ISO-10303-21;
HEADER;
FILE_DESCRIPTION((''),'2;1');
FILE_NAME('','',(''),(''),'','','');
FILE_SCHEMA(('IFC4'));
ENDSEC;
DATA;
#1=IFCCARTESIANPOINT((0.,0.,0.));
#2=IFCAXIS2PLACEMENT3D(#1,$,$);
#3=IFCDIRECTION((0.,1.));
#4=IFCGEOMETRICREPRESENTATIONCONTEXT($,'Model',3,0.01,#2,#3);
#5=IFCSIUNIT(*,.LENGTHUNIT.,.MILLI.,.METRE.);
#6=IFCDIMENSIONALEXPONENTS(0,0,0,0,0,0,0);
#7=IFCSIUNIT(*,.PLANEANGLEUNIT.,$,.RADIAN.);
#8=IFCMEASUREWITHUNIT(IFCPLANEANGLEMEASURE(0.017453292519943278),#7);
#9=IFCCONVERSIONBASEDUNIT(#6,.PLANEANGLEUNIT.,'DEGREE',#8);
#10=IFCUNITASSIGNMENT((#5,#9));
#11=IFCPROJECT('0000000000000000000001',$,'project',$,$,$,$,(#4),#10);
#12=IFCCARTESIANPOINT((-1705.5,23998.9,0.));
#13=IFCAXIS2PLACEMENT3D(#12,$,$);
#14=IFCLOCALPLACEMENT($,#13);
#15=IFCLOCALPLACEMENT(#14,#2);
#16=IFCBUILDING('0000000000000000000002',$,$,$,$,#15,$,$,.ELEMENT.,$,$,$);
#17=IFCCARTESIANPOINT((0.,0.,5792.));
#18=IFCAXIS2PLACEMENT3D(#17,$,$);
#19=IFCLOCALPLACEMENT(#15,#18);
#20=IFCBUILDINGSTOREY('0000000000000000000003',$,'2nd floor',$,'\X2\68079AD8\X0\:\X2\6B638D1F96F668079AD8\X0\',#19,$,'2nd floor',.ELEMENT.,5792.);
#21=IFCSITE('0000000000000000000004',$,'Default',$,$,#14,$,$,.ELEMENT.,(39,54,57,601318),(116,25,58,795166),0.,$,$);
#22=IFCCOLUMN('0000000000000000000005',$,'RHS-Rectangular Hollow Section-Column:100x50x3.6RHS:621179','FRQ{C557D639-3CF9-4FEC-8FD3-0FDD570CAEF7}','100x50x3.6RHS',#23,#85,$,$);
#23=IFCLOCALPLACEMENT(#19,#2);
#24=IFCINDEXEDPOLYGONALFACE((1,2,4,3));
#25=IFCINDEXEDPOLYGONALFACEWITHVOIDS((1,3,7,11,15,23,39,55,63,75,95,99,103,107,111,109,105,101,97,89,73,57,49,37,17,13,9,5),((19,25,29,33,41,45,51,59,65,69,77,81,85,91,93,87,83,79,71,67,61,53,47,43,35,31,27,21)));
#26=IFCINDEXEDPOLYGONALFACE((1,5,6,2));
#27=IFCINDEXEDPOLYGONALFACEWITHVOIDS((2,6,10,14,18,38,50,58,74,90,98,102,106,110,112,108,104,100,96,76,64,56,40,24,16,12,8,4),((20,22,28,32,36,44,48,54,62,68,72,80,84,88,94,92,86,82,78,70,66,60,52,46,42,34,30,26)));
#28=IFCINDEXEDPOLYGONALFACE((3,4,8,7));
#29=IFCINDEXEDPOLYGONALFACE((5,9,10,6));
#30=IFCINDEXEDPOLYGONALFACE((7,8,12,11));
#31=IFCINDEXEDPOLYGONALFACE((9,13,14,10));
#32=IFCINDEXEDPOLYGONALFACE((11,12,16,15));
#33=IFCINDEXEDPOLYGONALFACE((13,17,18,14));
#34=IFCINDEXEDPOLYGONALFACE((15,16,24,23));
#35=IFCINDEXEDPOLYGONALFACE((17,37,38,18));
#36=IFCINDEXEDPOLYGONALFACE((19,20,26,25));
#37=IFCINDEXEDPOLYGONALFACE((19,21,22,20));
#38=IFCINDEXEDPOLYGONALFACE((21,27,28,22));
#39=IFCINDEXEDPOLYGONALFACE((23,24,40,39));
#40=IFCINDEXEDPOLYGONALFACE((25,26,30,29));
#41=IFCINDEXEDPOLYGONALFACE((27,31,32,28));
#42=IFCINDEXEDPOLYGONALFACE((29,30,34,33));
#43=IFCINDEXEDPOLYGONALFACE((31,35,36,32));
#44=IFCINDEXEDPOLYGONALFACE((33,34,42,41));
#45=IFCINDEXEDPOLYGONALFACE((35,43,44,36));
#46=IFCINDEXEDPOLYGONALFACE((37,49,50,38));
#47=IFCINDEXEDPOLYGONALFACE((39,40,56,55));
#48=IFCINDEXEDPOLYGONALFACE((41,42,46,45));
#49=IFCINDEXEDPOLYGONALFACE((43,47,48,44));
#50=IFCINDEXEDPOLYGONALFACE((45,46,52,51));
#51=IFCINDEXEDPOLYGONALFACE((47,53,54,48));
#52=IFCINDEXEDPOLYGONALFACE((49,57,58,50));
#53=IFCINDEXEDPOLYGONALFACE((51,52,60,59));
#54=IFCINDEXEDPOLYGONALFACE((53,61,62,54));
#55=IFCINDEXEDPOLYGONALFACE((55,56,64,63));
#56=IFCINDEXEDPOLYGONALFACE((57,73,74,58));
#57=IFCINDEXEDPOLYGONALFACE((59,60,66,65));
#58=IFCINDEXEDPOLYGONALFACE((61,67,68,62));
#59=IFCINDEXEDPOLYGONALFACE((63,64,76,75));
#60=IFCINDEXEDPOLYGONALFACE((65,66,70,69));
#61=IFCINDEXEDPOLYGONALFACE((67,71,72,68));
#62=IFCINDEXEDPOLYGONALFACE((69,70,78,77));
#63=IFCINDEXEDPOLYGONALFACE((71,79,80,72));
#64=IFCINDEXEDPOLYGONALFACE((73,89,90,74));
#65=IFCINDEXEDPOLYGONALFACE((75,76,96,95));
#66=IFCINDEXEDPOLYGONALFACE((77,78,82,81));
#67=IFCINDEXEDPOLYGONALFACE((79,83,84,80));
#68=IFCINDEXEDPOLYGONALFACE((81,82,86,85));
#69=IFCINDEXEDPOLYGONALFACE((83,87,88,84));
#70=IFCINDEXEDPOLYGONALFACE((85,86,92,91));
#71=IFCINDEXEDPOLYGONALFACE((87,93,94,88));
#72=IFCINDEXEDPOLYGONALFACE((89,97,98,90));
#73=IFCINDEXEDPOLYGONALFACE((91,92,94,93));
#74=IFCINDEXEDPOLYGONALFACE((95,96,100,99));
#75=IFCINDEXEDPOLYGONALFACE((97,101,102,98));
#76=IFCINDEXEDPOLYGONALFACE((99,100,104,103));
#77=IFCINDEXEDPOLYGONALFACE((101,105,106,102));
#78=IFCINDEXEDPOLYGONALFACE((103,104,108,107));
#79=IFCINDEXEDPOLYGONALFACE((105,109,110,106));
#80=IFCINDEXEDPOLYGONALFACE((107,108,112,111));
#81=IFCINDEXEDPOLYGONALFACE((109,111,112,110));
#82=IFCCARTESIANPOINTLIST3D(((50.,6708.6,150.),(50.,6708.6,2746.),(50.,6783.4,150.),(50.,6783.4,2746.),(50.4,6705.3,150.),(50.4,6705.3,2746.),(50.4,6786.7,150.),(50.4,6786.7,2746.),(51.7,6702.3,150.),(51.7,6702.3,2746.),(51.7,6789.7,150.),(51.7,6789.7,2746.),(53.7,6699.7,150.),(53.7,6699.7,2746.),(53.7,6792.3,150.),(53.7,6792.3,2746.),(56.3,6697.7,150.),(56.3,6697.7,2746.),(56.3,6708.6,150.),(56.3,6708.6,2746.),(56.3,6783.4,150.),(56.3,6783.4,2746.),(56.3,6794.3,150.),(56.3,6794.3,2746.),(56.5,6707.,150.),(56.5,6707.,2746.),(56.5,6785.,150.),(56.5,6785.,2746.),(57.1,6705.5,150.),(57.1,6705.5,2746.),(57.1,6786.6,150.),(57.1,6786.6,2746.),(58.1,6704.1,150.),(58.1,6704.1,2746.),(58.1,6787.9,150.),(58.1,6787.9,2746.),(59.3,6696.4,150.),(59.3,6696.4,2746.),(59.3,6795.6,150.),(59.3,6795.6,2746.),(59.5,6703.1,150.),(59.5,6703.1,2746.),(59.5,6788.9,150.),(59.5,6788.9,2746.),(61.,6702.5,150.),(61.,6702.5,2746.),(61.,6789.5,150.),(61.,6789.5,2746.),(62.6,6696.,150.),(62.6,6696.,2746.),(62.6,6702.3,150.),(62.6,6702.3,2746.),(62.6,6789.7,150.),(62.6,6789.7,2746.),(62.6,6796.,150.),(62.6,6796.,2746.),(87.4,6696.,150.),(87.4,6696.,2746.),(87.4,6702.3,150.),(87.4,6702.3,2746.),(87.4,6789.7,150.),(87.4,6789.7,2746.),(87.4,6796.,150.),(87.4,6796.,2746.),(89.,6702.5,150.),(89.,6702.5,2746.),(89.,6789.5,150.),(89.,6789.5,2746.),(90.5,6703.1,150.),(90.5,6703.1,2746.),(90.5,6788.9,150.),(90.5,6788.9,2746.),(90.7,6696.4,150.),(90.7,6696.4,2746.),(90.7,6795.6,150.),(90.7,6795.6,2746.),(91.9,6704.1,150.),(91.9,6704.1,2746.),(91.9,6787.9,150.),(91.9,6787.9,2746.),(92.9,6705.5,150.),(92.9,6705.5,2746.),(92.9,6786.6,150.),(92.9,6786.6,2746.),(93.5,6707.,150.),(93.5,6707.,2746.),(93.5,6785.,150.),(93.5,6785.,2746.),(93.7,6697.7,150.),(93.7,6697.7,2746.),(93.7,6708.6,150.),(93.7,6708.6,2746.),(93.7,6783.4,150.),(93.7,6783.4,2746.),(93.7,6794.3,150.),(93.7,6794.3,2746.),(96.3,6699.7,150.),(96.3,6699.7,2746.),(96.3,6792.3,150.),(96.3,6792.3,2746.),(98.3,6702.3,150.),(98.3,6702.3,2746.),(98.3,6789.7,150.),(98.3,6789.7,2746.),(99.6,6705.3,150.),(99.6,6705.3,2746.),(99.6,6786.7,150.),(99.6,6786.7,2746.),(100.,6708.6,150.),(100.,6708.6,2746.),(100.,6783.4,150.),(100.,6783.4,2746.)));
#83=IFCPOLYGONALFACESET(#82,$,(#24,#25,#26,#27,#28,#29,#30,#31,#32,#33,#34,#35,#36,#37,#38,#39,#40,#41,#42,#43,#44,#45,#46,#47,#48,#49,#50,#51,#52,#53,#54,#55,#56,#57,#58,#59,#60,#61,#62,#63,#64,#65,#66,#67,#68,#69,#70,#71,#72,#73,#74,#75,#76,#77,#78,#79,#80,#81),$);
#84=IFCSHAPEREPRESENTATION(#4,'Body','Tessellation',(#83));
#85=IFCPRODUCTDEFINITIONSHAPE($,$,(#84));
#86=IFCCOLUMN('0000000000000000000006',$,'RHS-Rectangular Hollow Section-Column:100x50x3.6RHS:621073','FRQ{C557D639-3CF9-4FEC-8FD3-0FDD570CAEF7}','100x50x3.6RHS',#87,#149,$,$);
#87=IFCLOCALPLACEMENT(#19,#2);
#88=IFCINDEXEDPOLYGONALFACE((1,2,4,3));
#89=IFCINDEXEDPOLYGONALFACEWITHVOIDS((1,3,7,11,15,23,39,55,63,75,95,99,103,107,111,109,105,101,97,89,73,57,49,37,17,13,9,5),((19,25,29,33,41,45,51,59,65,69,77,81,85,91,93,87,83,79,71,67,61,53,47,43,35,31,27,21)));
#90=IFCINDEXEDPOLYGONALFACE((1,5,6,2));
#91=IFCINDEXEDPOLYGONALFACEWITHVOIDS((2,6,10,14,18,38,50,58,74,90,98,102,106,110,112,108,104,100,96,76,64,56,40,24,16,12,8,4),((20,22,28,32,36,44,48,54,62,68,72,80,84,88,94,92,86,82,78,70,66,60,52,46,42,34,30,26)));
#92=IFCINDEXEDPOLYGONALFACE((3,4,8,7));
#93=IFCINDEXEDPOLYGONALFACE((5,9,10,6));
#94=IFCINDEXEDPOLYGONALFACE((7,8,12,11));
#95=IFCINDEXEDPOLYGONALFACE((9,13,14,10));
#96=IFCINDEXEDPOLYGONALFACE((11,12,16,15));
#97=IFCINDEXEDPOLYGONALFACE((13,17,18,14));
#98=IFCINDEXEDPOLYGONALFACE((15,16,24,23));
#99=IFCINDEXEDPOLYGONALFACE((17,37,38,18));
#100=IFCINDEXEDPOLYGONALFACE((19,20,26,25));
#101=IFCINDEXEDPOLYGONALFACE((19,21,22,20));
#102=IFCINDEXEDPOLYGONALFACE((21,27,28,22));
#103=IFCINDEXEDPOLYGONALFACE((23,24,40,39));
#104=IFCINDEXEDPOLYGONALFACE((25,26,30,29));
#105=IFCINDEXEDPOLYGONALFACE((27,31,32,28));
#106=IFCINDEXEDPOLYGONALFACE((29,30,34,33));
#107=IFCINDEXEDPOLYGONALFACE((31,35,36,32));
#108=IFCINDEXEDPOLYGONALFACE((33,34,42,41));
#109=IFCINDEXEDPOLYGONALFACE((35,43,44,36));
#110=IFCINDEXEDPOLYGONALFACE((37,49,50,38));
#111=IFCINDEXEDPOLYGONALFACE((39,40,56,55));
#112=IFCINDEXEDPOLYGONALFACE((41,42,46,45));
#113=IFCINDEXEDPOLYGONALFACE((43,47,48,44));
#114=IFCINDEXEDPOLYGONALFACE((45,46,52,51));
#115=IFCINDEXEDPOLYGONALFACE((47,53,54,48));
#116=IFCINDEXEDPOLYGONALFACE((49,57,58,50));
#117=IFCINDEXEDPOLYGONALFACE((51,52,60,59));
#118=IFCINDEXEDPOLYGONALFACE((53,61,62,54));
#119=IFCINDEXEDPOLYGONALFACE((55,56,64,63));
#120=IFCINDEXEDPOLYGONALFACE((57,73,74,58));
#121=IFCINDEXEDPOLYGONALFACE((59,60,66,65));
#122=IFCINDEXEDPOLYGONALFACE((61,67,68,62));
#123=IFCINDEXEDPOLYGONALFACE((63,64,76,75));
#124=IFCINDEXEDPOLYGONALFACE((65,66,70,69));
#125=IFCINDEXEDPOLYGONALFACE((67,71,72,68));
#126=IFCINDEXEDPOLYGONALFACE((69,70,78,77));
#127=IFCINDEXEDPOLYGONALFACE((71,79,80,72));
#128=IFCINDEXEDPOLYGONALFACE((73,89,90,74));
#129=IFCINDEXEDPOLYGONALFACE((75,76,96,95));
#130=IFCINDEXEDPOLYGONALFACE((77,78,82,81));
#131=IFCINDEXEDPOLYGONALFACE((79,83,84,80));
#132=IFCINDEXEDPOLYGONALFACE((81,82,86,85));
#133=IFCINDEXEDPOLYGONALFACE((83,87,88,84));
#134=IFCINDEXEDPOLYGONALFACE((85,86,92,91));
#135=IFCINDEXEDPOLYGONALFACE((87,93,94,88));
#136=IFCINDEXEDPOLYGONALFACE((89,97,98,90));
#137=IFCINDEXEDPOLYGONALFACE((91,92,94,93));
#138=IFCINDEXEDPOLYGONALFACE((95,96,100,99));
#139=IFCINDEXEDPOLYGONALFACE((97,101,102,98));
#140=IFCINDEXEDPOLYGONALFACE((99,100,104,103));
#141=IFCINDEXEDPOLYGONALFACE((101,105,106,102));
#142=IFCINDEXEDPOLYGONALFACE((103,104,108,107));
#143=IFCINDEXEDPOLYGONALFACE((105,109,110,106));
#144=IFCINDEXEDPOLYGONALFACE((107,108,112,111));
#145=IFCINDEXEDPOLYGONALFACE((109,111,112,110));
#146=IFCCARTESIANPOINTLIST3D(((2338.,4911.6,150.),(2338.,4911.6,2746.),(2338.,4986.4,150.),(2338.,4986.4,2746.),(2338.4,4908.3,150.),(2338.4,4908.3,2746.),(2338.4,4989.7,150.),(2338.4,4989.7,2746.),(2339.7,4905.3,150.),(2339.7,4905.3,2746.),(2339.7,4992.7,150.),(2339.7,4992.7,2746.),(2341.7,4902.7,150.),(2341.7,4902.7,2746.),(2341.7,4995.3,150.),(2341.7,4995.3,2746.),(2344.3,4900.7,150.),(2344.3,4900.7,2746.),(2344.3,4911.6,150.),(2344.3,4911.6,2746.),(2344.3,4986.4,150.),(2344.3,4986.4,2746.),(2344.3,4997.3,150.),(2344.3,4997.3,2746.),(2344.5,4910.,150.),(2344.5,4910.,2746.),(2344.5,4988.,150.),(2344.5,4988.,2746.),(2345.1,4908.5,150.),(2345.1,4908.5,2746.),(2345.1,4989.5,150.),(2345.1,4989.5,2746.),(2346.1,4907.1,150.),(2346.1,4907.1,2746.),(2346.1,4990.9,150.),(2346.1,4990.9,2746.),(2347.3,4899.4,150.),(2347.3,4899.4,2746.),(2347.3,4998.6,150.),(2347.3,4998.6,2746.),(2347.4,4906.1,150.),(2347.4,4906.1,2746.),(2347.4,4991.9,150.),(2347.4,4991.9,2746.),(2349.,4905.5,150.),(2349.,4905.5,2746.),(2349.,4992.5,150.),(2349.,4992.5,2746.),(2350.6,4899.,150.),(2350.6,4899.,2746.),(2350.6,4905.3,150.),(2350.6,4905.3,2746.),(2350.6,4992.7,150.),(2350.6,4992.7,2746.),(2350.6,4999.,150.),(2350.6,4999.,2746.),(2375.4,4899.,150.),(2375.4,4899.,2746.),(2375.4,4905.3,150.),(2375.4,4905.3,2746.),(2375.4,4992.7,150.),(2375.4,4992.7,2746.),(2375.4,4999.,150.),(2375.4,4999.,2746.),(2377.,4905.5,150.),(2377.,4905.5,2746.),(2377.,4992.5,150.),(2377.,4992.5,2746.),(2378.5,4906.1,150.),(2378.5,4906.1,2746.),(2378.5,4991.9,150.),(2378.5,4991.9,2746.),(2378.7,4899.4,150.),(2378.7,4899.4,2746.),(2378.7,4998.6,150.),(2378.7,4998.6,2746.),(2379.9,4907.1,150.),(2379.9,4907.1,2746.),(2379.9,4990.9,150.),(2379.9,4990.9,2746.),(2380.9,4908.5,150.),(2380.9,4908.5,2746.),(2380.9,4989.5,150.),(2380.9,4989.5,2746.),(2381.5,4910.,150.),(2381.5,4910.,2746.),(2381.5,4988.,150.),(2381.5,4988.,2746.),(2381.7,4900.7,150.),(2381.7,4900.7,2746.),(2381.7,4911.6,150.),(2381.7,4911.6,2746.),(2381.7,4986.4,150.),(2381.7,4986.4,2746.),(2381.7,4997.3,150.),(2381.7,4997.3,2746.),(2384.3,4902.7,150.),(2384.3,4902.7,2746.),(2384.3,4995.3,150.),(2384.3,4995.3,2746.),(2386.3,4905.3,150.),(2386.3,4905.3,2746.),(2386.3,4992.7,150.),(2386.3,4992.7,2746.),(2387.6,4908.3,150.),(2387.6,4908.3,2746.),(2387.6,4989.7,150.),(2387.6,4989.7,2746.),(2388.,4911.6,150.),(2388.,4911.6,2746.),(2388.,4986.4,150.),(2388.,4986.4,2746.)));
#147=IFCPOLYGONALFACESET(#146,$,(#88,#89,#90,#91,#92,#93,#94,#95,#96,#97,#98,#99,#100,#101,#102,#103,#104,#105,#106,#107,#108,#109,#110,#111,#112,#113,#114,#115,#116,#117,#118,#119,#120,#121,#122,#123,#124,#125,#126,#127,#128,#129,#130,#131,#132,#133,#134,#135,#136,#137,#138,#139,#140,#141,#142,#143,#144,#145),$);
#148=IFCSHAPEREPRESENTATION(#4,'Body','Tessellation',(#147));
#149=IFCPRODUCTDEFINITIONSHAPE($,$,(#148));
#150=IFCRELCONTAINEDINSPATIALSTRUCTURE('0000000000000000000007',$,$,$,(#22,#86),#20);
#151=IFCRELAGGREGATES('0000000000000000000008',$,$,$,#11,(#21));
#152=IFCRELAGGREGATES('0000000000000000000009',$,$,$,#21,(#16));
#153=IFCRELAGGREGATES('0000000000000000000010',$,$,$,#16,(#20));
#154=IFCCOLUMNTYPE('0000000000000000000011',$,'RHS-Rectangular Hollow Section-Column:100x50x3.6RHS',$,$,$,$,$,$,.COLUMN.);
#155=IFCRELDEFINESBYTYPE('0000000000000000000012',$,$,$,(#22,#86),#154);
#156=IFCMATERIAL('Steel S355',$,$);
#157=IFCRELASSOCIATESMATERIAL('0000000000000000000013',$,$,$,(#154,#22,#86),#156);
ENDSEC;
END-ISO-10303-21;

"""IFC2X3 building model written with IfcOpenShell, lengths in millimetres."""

from ifc_helpers import new_model, entity, si_unit, converted_unit, direction, frame, origin, origin_2d, place, context, project, spatial, hollow_rectangle, extrude, clip, halfspace, material, type_object, element, save


model = new_model("IFC2X3")

# Units and contexts
model_context = context("Model", 3, precision=0.01, world=origin(), true_north=direction((0.0, 1.0)))
ifc_project = project(units=[si_unit("LENGTHUNIT", "METRE", prefix="MILLI"), converted_unit("PLANEANGLEUNIT", "DEGREE", entity("IfcPlaneAngleMeasure", 0.017453292519943278), si_unit("PLANEANGLEUNIT", "RADIAN"), dimensions=[0, 0, 0, 0, 0, 0, 0])], contexts=[model_context])

# Site, building, storey
site_placement = place(None, frame((-1705.5, 23998.9, 0.0)))
site = spatial("IfcSite", under=ifc_project, at=site_placement, Name="Default", CompositionType="ELEMENT", RefLatitude=(39, 54, 57, 601318), RefLongitude=(116, 25, 58, 795166), RefElevation=0.0)
building_placement = place(site_placement, origin())
building = spatial("IfcBuilding", under=site, at=building_placement, CompositionType="ELEMENT")
storey_placement = place(building_placement, frame((0.0, 0.0, 5792.0)))
storey = spatial("IfcBuildingStorey", under=building, at=storey_placement, Name="2nd floor", ObjectType="标高:正负零标高", LongName="2nd floor", CompositionType="ELEMENT", Elevation=5792.0)

# Columns
ifc_material_1 = material(Name="Steel S355")
column_type_1 = type_object("IfcColumnType", Name="RHS-Rectangular Hollow Section-Column:100x50x3.6RHS", PredefinedType="COLUMN", material=ifc_material_1)
column_1_placement = place(storey_placement, frame((75.0, 6746.0, 2746.0), z_axis=(0.0, 0.0, 1.0), x_axis=(-1.0, 0.0, 0.0)))
element("IfcColumn", 1, at=column_1_placement, inside=storey, type_object=column_type_1, material=ifc_material_1, Name="RHS-Rectangular Hollow Section-Column:100x50x3.6RHS:621179", Description="FRQ{C557D639-3CF9-4FEC-8FD3-0FDD570CAEF7}", ObjectType="100x50x3.6RHS", context=model_context, shape_type="Clipping", body=[
    clip(extrude(hollow_rectangle(XDim=50.0, YDim=100.0, WallThickness=6.3, InnerFilletRadius=6.3, OuterFilletRadius=12.6, at=origin_2d()), origin(), (0.0, 0.0, -1.0), 2651.9), halfspace(frame((75.0, 6746.0, -2596.0), z_axis=(0.0, 0.0, 1.0), x_axis=(-1.0, 0.0, 0.0)), True)),
])
column_2_placement = place(storey_placement, frame((2363.0, 4949.0, 2746.0), z_axis=(0.0, 0.0, 1.0), x_axis=(-1.0, 0.0, 0.0)))
element("IfcColumn", 2, at=column_2_placement, inside=storey, type_object=column_type_1, material=ifc_material_1, Name="RHS-Rectangular Hollow Section-Column:100x50x3.6RHS:621073", Description="FRQ{C557D639-3CF9-4FEC-8FD3-0FDD570CAEF7}", ObjectType="100x50x3.6RHS", context=model_context, shape_type="Clipping", body=[
    clip(extrude(hollow_rectangle(XDim=50.0, YDim=100.0, WallThickness=6.3, InnerFilletRadius=6.3, OuterFilletRadius=12.6, at=origin_2d()), origin(), (0.0, 0.0, -1.0), 2651.9), halfspace(frame((2363.0, 4949.0, -2596.0), z_axis=(0.0, 0.0, 1.0), x_axis=(-1.0, 0.0, 0.0)), True)),
])

save(model, "model.ifc")
